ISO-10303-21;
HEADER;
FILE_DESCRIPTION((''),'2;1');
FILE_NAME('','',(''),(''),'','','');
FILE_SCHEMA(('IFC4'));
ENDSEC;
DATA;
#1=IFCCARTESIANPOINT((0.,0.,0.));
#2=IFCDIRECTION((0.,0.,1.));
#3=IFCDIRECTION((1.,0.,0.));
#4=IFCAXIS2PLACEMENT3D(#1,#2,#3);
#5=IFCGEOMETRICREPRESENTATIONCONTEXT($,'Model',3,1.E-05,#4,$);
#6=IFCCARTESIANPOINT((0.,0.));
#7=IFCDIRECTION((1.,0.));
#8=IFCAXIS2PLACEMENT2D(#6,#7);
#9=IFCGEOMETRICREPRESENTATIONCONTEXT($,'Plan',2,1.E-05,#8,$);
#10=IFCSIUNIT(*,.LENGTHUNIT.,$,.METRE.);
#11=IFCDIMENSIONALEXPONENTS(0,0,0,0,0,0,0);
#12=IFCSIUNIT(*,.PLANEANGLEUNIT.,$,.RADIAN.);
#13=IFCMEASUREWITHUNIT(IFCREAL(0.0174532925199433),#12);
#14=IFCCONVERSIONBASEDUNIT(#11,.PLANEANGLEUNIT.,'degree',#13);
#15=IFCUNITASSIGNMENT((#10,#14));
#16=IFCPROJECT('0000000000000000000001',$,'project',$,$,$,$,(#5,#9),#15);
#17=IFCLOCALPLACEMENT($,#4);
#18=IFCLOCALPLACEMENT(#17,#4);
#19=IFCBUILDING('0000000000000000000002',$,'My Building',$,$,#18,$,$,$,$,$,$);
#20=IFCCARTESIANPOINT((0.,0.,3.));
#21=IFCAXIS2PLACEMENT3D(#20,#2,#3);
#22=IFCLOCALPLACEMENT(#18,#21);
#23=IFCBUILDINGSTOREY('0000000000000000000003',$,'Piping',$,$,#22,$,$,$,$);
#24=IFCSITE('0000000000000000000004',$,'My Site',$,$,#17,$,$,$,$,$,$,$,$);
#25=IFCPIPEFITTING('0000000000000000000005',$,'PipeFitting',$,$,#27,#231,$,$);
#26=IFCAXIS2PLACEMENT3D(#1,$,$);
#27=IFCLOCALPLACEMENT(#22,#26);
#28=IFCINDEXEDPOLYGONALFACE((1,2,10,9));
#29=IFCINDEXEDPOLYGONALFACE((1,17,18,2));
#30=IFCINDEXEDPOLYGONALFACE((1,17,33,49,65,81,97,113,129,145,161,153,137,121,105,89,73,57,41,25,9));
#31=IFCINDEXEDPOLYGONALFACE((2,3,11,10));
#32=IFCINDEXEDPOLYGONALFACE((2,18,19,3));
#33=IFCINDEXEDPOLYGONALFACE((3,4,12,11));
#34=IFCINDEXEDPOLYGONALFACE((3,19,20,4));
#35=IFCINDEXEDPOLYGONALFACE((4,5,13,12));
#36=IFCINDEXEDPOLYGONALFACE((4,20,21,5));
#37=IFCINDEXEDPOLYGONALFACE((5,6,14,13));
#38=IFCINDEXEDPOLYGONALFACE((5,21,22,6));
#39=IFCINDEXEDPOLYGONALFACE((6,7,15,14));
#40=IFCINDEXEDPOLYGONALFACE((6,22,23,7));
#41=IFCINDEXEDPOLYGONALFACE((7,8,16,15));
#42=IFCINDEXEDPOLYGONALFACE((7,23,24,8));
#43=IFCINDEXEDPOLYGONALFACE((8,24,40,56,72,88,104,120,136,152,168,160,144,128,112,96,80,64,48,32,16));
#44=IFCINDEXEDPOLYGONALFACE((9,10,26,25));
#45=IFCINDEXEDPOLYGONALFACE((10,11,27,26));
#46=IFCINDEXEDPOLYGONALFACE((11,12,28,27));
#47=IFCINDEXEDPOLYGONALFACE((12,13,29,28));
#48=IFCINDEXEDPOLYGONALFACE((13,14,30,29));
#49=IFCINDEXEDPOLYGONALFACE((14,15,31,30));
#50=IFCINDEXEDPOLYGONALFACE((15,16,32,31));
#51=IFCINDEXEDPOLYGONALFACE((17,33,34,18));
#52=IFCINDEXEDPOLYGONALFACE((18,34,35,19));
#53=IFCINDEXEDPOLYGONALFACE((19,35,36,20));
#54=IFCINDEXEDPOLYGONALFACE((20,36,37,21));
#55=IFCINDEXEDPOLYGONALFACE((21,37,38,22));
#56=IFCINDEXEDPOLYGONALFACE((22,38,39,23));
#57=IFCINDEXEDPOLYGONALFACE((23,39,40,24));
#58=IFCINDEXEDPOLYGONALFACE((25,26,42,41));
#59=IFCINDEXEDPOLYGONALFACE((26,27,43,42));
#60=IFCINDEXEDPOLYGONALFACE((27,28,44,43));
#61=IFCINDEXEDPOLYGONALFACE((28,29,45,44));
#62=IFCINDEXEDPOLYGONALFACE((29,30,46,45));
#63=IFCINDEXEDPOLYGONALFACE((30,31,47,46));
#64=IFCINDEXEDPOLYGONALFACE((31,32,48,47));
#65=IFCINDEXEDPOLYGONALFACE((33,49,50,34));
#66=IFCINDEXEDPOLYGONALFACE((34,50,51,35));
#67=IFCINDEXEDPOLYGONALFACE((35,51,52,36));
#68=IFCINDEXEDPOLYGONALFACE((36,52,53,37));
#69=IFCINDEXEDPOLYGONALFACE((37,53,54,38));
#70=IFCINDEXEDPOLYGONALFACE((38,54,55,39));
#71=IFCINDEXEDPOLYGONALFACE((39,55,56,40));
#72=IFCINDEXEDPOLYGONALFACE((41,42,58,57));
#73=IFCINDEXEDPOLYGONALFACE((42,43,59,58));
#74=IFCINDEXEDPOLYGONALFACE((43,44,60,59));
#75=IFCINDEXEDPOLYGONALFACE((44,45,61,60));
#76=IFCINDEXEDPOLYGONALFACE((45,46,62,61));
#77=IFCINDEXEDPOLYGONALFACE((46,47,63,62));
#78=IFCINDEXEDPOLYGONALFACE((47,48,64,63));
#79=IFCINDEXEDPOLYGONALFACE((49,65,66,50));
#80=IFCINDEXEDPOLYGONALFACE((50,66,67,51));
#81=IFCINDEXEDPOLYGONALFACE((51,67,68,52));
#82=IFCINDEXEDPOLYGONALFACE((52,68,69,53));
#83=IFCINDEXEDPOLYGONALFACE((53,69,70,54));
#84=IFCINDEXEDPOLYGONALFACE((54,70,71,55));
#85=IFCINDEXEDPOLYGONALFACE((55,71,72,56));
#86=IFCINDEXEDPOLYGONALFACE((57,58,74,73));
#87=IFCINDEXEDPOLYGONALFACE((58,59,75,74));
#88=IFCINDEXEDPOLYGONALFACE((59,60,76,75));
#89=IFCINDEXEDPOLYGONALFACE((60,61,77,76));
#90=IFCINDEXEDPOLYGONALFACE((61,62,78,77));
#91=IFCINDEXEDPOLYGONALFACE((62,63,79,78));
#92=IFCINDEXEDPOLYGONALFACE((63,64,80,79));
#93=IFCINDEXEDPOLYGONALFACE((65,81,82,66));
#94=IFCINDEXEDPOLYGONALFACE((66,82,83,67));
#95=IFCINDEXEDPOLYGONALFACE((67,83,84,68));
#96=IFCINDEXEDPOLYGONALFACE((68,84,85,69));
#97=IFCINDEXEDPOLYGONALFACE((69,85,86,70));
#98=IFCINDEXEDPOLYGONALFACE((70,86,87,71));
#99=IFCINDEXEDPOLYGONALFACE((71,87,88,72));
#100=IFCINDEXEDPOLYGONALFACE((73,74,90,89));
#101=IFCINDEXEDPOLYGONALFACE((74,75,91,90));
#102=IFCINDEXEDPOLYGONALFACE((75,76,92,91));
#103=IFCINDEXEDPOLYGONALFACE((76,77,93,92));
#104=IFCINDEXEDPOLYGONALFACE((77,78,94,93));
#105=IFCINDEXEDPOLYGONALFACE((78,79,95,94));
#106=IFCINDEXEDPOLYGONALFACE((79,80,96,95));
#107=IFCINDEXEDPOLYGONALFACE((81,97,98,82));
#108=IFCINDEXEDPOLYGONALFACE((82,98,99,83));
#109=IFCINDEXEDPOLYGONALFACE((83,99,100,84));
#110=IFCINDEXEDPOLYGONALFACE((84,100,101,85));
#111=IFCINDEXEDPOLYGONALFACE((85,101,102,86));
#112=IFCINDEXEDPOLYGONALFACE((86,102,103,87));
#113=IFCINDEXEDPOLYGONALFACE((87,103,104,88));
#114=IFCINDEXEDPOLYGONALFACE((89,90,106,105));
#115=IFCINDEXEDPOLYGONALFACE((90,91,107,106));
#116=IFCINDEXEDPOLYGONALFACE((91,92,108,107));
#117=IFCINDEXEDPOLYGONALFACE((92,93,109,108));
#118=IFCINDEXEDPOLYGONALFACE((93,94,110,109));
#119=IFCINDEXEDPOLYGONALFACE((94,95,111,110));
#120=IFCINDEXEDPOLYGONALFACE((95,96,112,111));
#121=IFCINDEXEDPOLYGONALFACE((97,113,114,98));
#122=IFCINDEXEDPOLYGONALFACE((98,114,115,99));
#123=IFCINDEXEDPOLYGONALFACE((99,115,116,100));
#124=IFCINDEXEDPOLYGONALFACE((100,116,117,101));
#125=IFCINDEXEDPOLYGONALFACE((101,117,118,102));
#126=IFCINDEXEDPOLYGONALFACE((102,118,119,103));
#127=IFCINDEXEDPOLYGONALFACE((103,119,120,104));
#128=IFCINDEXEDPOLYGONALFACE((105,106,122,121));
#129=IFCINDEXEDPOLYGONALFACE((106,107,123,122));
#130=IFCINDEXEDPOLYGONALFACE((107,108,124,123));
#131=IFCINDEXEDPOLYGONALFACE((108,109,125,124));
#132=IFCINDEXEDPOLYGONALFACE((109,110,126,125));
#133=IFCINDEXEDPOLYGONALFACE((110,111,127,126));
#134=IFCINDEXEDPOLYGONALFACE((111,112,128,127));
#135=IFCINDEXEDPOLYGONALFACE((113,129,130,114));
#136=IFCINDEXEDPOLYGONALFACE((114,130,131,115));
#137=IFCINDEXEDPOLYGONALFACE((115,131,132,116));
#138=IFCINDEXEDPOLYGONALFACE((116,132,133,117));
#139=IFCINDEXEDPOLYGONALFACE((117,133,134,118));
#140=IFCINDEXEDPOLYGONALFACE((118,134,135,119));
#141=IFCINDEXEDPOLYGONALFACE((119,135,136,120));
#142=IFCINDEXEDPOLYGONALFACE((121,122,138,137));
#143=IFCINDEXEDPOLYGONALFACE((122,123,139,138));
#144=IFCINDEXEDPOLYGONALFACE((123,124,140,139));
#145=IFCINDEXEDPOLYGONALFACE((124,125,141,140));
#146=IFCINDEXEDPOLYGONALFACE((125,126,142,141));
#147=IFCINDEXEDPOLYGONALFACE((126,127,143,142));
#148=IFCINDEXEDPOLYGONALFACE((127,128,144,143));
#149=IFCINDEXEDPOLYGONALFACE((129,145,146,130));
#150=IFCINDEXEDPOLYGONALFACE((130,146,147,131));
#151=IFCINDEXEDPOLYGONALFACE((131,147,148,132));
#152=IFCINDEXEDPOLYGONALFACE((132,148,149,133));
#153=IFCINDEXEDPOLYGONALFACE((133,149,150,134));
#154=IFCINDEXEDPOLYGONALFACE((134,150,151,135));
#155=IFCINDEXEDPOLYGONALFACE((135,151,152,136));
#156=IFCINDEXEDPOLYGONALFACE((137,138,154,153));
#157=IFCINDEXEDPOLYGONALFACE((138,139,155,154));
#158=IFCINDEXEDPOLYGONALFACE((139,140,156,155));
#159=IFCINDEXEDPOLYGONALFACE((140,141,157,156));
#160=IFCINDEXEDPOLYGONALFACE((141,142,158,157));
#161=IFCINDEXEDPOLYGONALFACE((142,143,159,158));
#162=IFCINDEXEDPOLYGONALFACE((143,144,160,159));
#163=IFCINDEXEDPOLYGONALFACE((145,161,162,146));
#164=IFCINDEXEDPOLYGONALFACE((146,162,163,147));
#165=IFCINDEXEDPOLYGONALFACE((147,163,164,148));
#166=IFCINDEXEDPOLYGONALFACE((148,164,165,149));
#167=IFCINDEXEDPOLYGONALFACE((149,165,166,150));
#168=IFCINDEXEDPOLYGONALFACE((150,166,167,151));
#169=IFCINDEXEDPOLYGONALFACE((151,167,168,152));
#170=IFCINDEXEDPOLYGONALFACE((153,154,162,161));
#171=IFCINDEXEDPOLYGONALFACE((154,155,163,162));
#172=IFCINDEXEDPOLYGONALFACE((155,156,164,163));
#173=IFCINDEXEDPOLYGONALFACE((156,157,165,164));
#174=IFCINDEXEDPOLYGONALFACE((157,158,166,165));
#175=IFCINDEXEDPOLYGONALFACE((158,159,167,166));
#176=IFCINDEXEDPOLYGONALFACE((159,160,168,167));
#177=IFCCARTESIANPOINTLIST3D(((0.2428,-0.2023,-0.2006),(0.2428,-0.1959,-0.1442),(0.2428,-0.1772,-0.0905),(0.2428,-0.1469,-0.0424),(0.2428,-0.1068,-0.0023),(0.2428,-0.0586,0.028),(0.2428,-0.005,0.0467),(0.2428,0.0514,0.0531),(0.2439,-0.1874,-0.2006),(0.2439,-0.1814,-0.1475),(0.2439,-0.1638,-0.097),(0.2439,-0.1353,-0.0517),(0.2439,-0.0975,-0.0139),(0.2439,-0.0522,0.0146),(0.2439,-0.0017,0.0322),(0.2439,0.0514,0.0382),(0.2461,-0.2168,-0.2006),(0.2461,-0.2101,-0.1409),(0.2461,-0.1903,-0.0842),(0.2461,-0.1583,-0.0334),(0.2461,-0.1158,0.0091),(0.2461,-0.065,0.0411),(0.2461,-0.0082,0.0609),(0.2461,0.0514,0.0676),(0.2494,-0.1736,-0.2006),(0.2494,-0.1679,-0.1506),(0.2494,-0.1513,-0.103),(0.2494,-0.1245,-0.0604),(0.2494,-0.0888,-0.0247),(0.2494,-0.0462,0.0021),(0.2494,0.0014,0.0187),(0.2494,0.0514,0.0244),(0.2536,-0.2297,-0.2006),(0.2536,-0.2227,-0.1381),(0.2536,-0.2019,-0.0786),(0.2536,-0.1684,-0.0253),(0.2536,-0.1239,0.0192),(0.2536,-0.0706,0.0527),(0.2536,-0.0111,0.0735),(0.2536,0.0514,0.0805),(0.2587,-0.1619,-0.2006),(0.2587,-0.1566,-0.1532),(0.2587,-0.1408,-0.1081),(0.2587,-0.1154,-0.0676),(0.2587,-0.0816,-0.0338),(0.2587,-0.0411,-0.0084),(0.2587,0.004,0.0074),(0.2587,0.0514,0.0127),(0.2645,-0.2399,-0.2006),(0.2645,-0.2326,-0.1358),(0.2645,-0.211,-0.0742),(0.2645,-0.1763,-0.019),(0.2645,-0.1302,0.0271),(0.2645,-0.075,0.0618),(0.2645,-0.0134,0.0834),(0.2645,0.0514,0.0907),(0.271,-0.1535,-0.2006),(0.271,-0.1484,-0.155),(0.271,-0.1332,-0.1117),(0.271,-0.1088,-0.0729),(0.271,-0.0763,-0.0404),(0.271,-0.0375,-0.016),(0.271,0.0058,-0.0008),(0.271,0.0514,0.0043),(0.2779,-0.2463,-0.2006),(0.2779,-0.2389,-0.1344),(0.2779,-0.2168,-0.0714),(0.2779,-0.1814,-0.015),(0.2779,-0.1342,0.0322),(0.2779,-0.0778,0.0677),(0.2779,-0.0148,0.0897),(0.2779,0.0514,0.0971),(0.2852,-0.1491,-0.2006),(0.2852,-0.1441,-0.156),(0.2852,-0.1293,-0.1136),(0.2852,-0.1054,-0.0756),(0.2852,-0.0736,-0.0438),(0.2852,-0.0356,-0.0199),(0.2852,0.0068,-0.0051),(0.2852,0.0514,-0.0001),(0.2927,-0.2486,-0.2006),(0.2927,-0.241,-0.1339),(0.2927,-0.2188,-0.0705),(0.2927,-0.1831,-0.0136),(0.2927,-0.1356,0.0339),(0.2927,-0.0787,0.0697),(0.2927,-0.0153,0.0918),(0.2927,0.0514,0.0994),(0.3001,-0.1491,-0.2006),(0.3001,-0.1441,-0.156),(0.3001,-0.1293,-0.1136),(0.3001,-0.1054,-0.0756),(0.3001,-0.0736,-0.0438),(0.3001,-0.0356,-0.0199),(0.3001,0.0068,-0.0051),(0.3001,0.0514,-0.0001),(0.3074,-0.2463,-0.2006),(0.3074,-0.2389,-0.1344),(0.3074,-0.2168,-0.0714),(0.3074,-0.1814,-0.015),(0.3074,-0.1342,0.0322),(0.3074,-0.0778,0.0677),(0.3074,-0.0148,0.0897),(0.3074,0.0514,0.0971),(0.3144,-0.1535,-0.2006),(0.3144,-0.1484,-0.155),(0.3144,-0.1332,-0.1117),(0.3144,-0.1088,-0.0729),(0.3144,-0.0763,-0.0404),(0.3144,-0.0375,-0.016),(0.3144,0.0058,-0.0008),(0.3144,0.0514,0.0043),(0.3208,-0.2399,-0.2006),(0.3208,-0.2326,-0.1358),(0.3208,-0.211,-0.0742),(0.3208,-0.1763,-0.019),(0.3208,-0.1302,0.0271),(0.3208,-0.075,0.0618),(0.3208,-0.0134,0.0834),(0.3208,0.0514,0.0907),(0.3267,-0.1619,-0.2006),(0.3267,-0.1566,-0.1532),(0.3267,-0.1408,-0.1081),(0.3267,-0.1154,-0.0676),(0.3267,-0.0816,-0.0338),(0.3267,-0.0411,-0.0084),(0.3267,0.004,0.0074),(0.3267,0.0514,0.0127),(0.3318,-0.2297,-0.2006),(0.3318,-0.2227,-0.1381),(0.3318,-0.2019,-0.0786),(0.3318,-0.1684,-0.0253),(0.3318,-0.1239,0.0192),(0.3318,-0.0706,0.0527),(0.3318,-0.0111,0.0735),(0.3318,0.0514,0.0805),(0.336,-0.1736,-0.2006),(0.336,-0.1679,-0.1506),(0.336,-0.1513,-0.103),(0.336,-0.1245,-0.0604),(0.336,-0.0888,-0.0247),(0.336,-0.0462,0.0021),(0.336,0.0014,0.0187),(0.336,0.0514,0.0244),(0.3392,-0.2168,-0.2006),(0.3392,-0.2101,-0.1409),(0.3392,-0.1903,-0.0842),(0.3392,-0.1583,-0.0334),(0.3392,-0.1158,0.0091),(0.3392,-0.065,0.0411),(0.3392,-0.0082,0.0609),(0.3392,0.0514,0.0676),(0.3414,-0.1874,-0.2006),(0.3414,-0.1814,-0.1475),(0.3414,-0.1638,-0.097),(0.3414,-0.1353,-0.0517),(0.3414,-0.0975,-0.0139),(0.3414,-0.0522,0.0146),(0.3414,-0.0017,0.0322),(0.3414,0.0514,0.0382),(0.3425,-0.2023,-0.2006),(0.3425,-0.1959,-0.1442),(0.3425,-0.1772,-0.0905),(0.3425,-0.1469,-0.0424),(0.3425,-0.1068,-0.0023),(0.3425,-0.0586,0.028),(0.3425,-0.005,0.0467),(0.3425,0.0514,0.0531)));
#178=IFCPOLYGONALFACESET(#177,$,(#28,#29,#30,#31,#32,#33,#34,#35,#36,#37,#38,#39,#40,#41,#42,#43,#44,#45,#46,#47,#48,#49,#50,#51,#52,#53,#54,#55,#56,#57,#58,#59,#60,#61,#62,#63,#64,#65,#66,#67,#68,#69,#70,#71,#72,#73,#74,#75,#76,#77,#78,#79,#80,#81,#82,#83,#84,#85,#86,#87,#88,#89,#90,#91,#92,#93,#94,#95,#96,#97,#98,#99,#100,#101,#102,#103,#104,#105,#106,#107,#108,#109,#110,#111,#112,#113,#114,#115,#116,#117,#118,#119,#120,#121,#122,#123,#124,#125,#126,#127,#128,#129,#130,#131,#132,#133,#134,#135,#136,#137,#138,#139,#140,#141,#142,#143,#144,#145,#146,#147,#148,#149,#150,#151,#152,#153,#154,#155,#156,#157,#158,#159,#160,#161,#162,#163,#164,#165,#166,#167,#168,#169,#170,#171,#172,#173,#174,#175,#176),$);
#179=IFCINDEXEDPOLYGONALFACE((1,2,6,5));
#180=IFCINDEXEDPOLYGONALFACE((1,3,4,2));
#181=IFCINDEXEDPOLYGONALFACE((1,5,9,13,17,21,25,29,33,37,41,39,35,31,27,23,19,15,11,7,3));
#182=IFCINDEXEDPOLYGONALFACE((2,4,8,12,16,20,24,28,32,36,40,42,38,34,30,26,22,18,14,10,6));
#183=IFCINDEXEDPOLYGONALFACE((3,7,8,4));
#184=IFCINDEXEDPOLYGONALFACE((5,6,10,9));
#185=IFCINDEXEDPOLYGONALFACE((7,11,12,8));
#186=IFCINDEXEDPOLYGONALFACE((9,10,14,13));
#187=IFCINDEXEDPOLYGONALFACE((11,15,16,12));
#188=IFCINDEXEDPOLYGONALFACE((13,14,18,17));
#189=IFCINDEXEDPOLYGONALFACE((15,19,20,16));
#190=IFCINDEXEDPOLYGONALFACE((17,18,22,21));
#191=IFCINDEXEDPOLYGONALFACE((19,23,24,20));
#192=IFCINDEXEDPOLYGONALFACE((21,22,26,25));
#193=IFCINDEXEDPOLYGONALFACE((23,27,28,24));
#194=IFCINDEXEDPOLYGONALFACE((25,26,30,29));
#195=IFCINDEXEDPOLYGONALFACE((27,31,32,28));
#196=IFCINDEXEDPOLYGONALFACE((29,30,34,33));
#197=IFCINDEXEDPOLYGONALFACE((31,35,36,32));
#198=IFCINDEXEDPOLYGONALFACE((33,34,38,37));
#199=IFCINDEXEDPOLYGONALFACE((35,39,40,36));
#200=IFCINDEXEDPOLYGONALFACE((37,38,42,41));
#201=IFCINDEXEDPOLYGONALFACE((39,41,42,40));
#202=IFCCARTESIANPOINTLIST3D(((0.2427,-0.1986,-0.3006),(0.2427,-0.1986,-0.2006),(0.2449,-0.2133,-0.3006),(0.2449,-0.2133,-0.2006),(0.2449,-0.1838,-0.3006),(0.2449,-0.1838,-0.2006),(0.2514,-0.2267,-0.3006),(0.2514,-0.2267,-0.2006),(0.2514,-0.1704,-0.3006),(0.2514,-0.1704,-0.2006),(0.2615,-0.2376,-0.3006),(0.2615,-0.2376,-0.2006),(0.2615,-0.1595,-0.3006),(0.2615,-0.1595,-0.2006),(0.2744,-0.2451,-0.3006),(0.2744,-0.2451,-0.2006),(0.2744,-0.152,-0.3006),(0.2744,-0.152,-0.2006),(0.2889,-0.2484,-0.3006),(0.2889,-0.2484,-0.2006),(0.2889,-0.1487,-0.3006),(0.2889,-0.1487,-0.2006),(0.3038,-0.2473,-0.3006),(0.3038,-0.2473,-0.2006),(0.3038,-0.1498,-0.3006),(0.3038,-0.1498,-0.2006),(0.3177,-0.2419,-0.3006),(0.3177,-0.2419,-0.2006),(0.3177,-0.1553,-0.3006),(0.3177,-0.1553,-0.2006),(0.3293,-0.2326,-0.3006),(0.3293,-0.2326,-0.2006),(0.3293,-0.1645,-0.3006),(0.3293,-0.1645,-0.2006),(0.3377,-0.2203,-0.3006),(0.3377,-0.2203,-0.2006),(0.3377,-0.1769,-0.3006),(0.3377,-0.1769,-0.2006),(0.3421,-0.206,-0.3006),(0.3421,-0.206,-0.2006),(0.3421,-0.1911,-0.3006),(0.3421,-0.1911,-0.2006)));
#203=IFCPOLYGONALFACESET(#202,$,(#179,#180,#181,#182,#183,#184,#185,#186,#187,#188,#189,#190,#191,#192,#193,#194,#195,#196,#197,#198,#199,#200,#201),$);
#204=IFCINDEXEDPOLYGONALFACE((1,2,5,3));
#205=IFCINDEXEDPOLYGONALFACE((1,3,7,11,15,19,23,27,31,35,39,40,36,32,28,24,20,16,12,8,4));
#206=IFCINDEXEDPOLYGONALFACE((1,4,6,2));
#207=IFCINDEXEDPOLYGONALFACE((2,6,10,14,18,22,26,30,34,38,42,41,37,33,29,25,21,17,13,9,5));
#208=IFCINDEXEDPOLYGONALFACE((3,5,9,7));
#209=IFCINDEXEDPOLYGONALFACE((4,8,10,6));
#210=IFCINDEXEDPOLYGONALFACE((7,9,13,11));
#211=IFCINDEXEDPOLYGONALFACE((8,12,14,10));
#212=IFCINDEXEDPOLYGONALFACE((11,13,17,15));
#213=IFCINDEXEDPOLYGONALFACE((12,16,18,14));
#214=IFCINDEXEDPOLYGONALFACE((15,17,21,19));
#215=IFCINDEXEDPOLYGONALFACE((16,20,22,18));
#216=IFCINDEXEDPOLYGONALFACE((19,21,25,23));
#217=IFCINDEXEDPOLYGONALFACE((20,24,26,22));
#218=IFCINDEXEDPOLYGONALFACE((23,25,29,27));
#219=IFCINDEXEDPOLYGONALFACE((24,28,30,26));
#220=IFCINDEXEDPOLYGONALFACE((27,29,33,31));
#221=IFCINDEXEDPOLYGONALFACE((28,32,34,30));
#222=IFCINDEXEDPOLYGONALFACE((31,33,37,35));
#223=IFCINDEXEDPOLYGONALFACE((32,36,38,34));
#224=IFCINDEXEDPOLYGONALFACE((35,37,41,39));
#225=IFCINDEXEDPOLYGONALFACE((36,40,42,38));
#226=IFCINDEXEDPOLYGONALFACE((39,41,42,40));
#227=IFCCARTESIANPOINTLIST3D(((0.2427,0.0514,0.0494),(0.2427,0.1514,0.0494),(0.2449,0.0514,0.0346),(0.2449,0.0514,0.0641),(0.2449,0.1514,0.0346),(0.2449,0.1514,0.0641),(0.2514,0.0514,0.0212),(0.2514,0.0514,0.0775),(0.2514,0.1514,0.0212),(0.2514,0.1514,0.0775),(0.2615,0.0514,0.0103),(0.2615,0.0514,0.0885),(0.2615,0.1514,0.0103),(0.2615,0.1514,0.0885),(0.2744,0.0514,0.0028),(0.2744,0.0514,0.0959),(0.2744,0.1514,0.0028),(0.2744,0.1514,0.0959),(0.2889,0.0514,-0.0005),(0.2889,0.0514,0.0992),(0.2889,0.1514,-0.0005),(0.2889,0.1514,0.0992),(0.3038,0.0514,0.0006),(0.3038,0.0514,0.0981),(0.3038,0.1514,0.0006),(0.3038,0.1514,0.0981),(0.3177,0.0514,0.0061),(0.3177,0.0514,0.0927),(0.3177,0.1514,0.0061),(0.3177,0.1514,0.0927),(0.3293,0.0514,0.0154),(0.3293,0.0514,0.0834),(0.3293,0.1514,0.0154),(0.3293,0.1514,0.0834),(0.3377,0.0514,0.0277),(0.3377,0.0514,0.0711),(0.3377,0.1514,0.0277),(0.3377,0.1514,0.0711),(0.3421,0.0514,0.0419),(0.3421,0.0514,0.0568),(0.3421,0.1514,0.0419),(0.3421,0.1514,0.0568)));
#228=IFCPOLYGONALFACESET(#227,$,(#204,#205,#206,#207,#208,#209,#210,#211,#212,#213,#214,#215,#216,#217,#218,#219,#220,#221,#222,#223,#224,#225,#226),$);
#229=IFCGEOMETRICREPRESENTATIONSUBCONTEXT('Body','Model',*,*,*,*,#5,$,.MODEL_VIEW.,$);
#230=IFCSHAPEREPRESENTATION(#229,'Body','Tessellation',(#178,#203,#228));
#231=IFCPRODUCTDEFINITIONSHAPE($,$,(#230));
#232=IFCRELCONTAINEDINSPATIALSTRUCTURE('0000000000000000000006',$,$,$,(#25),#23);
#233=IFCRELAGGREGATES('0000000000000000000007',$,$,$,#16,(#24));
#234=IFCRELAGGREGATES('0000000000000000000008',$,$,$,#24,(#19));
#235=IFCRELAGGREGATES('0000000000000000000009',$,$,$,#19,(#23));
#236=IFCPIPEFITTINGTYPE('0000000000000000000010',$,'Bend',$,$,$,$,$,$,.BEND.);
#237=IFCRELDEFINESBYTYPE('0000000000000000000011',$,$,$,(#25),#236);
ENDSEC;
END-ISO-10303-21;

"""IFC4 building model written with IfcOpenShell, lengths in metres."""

from ifc_helpers import new_model, entity, si_unit, converted_unit, frame, origin_with_axes, origin_2d_with_axis, place, context, subcontext, project, spatial, circle, extrude, source, transform, mapped, type_object, type_shapes, element, save


model = new_model("IFC4")

# Units and contexts
model_context = context("Model", 3, precision=1e-05, world=origin_with_axes())
plan_context = context("Plan", 2, precision=1e-05, world=origin_2d_with_axis())
body_context = subcontext(model_context, "Body", "Model", "MODEL_VIEW")
ifc_project = project(units=[si_unit("LENGTHUNIT", "METRE"), converted_unit("PLANEANGLEUNIT", "degree", entity("IfcReal", 0.0174532925199433), si_unit("PLANEANGLEUNIT", "RADIAN"), dimensions=[0, 0, 0, 0, 0, 0, 0])], contexts=[model_context, plan_context])

# Site, building, storey
site_placement = place(None, origin_with_axes())
site = spatial("IfcSite", under=ifc_project, at=site_placement, Name="My Site")
building_placement = place(site_placement, origin_with_axes())
building = spatial("IfcBuilding", under=site, at=building_placement, Name="My Building")
storey_placement = place(building_placement, frame((0.0, 0.0, 3.0), z_axis=(0.0, 0.0, 1.0), x_axis=(1.0, 0.0, 0.0)))
storey = spatial("IfcBuildingStorey", under=building, at=storey_placement, Name="Piping")

# Pipe fitting
pipe_fitting_type = type_object("IfcPipeFittingType", Name="Bend", PredefinedType="BEND")
shared_shape = source(origin_with_axes(), body_context, "Body", "SolidModel", [
    entity("IfcSweptDiskSolid", entity("IfcIndexedPolyCurve", entity("IfcCartesianPointList3D", [[0.0, 0.0, -0.1], [0.0, 0.0732, -0.2768], [0.0, 0.25, -0.35]]), [entity("IfcArcIndex", [1, 2, 3])]), 0.05),
    extrude(circle(Radius=0.05), origin_with_axes(), (0.0, 0.0, -1.0), 0.1),
    extrude(circle(Radius=0.05), frame((0.0, 0.25, -0.35), z_axis=(0.0, 1.0, 0.000007), x_axis=(1.0, 0.0, 0.0)), (0.0, 0.0, 1.0), 0.1),
])
type_shapes(pipe_fitting_type, [shared_shape])
for number, where, z_axis, x_axis, name in (
    (1, (0.2927, -0.1986, -0.3006), (0.0, 0.0, -1.0), (-1.0, 0.0, 0.0), "PipeFitting"),
):
    element("IfcPipeFitting", number, at=place(storey_placement, frame(where, z_axis=z_axis, x_axis=x_axis)), inside=storey, type_object=pipe_fitting_type, Name=name, context=body_context, shape_type="MappedRepresentation", body=[
        mapped(shared_shape, transform((0.0, 0.0, 0.0), x_axis=(1.0, 0.0, 0.0), y_axis=(0.0, 1.0, 0.0), z_axis=(0.0, 0.0, 1.0), scale=1.0)),
    ])

save(model, "model.ifc")
